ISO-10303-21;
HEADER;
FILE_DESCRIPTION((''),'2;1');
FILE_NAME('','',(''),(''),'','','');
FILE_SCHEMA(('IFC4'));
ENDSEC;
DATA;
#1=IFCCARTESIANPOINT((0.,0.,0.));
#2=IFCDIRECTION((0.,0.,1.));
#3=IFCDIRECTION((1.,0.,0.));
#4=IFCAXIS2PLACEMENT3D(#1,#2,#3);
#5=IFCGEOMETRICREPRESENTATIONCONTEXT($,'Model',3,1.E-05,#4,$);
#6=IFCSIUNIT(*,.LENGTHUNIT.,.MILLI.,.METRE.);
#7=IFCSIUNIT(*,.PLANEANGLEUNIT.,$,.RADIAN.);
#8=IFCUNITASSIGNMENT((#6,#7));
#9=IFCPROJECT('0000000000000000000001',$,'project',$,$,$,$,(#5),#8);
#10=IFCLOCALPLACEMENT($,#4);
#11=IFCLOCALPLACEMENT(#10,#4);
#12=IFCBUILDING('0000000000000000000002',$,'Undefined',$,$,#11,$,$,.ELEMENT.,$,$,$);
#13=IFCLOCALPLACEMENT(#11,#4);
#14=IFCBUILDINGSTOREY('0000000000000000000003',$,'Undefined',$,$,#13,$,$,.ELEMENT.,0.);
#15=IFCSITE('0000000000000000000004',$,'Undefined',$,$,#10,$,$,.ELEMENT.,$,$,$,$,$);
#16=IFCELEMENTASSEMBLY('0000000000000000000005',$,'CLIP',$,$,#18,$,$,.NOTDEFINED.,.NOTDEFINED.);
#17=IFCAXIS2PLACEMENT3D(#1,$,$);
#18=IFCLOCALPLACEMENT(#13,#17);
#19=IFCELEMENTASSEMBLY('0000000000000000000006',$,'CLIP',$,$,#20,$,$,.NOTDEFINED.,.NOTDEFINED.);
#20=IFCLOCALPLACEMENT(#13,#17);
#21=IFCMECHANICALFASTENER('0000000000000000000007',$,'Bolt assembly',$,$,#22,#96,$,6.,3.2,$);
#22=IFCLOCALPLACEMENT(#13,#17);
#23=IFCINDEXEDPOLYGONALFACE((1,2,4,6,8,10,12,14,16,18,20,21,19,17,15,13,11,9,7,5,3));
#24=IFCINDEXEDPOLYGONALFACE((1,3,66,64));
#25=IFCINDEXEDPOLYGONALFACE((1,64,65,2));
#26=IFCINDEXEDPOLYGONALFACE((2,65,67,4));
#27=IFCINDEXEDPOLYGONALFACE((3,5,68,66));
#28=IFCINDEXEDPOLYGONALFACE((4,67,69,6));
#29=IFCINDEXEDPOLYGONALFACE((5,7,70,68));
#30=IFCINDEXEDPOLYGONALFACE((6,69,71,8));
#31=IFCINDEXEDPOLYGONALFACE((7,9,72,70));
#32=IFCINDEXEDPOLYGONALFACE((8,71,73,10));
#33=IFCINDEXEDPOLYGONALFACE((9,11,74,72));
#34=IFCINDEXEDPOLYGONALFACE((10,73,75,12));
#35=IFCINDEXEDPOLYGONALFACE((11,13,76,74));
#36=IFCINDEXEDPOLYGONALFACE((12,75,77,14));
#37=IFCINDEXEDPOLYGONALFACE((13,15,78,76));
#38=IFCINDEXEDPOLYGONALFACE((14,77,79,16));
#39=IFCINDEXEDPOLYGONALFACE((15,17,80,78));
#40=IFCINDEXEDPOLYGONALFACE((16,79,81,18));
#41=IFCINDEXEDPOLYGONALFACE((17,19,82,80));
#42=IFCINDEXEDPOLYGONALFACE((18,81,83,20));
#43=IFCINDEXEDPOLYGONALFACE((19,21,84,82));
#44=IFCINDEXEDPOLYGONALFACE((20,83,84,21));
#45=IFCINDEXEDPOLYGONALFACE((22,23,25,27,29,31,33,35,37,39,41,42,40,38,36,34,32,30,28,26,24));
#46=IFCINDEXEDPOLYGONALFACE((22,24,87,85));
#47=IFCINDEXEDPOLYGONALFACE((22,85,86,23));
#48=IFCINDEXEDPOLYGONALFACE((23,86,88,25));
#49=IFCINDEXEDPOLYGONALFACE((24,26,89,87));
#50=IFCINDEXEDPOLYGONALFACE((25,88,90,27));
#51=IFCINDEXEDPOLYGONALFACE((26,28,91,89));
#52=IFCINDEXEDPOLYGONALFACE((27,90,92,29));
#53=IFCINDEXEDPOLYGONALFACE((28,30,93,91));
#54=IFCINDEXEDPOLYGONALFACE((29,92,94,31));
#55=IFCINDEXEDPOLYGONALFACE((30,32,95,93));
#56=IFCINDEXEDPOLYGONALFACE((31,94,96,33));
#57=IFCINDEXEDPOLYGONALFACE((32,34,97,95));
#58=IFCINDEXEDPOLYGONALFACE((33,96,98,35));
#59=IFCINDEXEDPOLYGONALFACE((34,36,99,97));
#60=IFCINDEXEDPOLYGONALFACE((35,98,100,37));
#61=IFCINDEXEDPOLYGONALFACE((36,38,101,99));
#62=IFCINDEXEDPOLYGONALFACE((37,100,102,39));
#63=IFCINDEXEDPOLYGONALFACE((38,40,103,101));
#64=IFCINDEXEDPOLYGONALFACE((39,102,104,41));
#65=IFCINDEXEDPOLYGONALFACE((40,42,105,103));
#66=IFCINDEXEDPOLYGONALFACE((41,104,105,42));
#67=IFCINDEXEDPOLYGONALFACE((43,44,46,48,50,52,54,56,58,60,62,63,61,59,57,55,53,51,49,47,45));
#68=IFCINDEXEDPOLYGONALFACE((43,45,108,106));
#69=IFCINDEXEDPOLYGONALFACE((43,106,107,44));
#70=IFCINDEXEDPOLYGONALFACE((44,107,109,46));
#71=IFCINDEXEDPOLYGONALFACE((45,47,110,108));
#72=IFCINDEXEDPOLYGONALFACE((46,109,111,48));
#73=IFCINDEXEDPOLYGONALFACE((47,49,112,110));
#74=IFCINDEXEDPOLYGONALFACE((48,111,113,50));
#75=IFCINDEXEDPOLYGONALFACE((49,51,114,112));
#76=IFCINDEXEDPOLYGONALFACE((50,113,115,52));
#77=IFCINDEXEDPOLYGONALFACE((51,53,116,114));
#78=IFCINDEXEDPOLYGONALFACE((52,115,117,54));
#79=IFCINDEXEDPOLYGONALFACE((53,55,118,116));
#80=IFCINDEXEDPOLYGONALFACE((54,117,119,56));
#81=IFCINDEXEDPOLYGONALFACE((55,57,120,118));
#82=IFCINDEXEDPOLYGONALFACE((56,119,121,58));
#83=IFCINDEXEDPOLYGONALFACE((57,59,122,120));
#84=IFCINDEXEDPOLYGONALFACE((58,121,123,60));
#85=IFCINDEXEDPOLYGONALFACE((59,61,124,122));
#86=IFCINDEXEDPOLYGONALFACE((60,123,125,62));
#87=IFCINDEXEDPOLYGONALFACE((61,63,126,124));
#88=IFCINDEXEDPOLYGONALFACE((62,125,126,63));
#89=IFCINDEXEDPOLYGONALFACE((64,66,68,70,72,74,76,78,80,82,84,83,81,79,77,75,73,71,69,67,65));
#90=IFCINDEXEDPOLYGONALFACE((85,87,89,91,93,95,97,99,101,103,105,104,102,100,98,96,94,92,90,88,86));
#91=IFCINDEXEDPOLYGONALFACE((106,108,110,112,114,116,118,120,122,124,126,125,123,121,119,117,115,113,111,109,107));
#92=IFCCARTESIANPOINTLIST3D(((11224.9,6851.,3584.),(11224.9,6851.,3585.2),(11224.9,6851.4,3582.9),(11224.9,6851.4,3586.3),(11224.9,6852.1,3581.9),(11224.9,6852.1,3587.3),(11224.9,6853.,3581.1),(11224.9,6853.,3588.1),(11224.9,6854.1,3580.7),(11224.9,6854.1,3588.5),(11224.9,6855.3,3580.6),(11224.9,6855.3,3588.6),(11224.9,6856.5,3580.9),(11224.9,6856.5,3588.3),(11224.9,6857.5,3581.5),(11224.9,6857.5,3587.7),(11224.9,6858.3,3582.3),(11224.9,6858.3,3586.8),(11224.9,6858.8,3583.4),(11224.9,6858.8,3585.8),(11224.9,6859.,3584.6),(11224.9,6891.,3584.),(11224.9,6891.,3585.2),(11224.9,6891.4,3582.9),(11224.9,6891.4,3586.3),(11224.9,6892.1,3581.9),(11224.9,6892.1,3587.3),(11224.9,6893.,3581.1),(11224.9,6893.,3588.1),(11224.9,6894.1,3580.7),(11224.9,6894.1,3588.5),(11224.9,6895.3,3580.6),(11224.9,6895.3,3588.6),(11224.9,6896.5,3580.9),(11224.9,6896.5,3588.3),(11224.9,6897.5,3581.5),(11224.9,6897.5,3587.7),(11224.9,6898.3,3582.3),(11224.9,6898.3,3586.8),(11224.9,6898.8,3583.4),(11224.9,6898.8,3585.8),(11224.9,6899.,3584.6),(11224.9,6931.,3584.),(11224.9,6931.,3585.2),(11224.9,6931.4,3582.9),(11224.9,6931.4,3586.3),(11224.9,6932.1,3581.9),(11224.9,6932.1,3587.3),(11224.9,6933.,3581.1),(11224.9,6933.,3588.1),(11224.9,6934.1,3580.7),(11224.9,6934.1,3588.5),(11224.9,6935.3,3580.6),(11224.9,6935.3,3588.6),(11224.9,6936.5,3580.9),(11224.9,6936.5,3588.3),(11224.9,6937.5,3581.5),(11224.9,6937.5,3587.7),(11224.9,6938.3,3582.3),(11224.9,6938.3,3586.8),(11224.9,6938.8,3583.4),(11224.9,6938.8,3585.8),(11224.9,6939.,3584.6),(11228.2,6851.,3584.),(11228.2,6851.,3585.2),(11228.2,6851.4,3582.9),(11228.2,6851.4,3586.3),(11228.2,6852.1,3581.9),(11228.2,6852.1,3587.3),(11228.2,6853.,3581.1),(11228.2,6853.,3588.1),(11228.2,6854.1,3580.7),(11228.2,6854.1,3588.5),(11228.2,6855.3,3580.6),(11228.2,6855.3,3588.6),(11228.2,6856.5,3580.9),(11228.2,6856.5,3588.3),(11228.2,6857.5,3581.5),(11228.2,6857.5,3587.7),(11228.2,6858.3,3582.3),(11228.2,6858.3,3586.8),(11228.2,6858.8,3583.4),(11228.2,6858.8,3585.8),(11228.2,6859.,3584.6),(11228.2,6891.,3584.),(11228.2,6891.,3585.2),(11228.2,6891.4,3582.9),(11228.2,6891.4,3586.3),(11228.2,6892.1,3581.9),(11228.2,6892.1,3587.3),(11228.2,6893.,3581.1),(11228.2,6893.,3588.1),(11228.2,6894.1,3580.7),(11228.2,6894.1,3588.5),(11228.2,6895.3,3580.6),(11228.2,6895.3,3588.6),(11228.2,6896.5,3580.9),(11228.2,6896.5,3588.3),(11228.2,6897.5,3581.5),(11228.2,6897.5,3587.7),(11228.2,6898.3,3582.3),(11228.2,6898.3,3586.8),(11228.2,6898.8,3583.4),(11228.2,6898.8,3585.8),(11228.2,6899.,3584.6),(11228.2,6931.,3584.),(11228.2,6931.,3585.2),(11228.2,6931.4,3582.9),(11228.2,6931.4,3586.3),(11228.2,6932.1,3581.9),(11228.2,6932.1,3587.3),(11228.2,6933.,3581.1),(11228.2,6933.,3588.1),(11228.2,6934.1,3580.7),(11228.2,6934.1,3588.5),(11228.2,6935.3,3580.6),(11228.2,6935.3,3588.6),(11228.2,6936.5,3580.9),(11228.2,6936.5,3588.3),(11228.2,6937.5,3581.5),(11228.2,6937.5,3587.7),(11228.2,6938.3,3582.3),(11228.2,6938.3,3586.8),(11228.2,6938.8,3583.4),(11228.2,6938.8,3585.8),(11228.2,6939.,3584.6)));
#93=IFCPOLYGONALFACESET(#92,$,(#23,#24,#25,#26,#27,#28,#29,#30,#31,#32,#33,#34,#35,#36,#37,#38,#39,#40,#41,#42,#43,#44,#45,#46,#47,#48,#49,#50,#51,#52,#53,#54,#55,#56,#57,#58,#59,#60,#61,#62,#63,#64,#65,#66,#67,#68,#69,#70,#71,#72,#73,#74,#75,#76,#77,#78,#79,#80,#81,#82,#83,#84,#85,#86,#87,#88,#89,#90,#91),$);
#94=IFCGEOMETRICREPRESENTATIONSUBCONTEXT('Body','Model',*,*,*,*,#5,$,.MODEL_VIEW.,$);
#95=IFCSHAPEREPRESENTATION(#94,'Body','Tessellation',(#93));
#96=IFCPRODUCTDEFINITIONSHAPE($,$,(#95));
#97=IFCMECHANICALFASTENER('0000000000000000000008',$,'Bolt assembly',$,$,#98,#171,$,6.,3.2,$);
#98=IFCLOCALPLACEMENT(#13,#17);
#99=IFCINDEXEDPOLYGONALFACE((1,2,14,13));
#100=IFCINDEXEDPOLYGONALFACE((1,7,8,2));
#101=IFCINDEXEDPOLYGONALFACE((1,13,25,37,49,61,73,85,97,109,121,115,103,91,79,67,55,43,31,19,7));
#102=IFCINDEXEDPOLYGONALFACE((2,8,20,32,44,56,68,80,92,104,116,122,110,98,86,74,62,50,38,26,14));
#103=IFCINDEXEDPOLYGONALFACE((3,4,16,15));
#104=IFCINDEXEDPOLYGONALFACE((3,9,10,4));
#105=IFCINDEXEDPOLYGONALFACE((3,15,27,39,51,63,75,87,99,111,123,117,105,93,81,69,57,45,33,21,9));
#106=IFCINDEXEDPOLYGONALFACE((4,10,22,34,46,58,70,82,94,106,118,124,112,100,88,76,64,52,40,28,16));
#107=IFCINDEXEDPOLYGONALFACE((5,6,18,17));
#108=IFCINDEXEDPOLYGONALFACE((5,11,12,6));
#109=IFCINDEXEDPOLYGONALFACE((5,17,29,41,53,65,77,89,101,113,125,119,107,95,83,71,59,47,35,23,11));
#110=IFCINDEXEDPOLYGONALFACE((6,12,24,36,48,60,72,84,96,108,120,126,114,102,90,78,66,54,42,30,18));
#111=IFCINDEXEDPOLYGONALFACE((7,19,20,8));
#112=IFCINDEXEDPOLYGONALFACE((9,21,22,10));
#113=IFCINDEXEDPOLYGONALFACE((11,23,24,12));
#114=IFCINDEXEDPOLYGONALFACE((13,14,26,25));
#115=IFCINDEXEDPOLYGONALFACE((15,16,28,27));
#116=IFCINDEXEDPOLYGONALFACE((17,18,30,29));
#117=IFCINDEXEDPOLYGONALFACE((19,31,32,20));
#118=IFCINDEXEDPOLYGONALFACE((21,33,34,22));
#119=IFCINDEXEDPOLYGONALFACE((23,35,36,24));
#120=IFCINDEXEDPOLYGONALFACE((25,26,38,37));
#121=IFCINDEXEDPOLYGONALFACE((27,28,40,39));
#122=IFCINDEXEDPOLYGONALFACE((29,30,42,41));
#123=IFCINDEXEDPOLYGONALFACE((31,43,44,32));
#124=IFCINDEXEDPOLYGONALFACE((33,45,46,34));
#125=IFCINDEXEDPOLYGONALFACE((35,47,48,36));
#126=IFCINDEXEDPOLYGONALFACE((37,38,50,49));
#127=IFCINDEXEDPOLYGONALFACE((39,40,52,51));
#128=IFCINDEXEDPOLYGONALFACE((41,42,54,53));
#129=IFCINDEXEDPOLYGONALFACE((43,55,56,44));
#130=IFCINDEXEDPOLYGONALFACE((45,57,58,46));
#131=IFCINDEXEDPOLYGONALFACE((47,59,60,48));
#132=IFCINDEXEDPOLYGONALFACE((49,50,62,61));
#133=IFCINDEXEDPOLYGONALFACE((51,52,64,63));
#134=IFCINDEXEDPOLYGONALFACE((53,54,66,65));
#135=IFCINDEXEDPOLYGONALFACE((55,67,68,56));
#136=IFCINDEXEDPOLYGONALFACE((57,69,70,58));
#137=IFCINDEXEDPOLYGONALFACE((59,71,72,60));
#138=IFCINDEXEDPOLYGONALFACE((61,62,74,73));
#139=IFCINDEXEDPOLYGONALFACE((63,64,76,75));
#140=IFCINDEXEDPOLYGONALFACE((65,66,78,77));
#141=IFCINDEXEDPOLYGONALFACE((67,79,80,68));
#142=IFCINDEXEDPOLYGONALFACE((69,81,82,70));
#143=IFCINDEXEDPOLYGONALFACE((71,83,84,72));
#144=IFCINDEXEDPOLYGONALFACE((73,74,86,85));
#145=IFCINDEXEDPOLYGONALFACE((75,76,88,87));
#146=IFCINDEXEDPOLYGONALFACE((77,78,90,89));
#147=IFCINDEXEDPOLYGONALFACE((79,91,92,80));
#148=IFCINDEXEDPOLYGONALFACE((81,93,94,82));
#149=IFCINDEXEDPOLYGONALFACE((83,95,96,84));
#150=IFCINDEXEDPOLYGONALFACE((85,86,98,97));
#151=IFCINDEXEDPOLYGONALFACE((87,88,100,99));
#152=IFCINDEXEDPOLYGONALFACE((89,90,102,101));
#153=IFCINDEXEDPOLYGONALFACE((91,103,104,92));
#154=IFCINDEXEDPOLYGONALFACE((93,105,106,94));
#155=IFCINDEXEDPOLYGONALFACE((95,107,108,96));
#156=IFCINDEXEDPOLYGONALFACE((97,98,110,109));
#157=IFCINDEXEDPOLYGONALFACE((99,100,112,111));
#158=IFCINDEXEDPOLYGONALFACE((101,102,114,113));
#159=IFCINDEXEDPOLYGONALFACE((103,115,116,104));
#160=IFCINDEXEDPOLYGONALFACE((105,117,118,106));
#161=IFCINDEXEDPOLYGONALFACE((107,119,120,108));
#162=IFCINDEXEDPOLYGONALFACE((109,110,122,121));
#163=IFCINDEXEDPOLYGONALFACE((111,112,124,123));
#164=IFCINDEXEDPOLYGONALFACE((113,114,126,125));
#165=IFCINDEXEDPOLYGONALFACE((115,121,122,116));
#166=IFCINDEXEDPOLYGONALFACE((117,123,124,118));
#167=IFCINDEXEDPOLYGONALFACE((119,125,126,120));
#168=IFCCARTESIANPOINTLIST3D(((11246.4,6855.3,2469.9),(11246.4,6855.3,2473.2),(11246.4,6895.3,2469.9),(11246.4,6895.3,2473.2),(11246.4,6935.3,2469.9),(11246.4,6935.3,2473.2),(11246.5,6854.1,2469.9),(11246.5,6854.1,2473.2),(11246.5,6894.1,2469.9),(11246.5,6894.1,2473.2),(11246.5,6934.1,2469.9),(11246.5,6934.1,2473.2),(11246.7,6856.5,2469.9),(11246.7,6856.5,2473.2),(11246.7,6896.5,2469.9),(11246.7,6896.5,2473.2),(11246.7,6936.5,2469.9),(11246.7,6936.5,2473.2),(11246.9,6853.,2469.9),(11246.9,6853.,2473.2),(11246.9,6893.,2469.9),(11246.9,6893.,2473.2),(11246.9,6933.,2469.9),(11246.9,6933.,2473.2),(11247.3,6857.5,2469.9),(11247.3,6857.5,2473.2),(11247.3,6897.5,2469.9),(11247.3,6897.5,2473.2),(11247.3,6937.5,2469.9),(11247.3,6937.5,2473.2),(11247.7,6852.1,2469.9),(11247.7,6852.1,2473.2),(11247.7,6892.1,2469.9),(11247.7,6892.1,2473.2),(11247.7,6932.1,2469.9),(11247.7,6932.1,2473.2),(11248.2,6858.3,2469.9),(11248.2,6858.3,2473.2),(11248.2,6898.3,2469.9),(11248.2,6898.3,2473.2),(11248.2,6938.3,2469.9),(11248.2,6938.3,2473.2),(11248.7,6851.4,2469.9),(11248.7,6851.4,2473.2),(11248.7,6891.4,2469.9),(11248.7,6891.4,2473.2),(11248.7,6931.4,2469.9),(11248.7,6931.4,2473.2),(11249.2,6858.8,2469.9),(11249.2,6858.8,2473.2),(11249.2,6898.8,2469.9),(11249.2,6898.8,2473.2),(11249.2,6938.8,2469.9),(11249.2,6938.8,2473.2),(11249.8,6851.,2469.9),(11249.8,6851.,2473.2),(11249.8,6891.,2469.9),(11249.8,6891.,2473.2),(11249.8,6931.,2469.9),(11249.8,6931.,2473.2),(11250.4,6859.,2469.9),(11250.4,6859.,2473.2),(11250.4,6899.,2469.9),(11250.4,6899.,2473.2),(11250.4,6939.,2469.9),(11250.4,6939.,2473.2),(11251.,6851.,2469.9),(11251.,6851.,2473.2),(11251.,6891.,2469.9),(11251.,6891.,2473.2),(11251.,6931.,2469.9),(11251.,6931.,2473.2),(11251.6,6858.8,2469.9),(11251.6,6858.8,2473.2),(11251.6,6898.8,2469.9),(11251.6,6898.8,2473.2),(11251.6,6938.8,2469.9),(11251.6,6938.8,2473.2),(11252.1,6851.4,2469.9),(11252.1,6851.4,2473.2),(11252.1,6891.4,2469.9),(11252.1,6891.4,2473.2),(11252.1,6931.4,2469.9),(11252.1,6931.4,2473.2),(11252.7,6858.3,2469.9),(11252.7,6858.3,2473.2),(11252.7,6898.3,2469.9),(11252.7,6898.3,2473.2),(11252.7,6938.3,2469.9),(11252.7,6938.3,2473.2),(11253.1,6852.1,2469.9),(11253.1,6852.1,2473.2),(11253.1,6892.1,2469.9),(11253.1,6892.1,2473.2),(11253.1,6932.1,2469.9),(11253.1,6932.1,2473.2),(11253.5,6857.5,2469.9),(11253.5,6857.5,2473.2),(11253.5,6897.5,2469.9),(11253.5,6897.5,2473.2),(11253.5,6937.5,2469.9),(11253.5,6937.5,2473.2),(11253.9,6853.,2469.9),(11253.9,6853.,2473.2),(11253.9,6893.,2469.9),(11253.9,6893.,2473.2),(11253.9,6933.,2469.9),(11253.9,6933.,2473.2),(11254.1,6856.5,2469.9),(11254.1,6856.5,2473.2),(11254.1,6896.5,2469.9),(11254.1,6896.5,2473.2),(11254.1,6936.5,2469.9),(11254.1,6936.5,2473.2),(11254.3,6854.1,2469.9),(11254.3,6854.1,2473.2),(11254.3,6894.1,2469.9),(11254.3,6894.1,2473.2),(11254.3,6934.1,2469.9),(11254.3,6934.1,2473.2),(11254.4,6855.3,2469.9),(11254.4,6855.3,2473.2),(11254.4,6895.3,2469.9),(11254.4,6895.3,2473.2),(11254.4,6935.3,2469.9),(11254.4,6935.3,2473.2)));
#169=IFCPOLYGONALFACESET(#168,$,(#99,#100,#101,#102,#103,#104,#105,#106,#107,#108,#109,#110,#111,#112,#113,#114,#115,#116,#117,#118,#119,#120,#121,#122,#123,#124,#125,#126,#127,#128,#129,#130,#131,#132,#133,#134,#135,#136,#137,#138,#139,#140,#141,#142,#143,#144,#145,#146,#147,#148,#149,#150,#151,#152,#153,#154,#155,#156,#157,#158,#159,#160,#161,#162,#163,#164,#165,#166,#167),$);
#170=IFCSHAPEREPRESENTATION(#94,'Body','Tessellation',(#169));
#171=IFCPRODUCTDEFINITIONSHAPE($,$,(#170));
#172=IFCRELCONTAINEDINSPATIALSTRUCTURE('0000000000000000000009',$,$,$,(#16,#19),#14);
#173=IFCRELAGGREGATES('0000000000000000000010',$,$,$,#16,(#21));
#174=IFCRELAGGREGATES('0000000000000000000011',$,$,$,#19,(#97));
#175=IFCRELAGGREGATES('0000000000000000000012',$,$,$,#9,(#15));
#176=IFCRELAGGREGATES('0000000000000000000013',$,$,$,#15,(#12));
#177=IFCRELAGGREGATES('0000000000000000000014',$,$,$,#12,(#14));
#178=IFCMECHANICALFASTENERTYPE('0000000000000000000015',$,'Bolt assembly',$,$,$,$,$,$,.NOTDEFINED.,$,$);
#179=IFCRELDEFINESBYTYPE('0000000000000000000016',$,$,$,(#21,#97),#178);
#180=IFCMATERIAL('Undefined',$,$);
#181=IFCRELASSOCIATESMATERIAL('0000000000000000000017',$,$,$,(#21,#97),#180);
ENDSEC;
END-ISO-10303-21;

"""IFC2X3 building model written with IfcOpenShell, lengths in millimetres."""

from ifc_helpers import new_model, si_unit, frame, origin_with_axes, origin_2d_with_axis, place, context, subcontext, project, spatial, circle, extrude, source, transform, mapped, material, type_object, element, aggregate, save


model = new_model("IFC2X3")

# Units and contexts
model_context = context("Model", 3, precision=1e-05, world=origin_with_axes())
body_context = subcontext(model_context, "Body", "Model", "MODEL_VIEW")
ifc_project = project(units=[si_unit("LENGTHUNIT", "METRE", prefix="MILLI"), si_unit("PLANEANGLEUNIT", "RADIAN")], contexts=[model_context])

# Site, building, storey
site_placement = place(None, origin_with_axes())
site = spatial("IfcSite", under=ifc_project, at=site_placement, Name="Undefined", CompositionType="ELEMENT")
building_placement = place(site_placement, origin_with_axes())
building = spatial("IfcBuilding", under=site, at=building_placement, Name="Undefined", CompositionType="ELEMENT")
storey_placement = place(building_placement, origin_with_axes())
storey = spatial("IfcBuildingStorey", under=building, at=storey_placement, Name="Undefined", CompositionType="ELEMENT", Elevation=0.0)

# Element assemblies
assembly_1_placement = place(storey_placement, origin_with_axes())
assembly_1 = element("IfcElementAssembly", 1, at=assembly_1_placement, inside=storey, Name="CLIP", AssemblyPlace="NOTDEFINED", PredefinedType="NOTDEFINED")
assembly_2_placement = place(storey_placement, origin_with_axes())
assembly_2 = element("IfcElementAssembly", 2, at=assembly_2_placement, inside=storey, Name="CLIP", AssemblyPlace="NOTDEFINED", PredefinedType="NOTDEFINED")

# Mechanical fasteners
ifc_material_1 = material(Name="Undefined")
mechanical_fastener_type = type_object("IfcMechanicalFastenerType", Name="Bolt assembly")
shared_shape_1 = source(origin_with_axes(), body_context, "Body", "SweptSolid", [
    extrude(circle(Radius=4.0, at=origin_2d_with_axis()), frame((0.0, -3.2, 0.0), z_axis=(0.0, 1.0, 0.0), x_axis=(1.0, 0.0, 0.0)), (0.0, 0.0, 1.0), 3.3),
])
mechanical_fastener_1_placement = place(assembly_1_placement, frame((11225.0, 6855.0, 3584.6), z_axis=(0.0, 0.0, 1.0), x_axis=(0.0, 1.0, 0.0)))
mechanical_fastener_1 = element("IfcMechanicalFastener", 3, at=mechanical_fastener_1_placement, type_object=mechanical_fastener_type, material=ifc_material_1, Name="Bolt assembly", NominalDiameter=6.0, NominalLength=3.2, context=body_context, shape_type="MappedRepresentation", body=[
    mapped(shared_shape_1, transform((0.0, 0.0, 0.0))),
    mapped(shared_shape_1, transform((40.0, 0.0, 0.0))),
    mapped(shared_shape_1, transform((80.0, 0.0, 0.0))),
])
mechanical_fastener_2_placement = place(assembly_2_placement, frame((11250.4, 6855.0, 2470.0), z_axis=(-1.0, 0.0, 0.0), x_axis=(0.0, 1.0, 0.0)))
mechanical_fastener_2 = element("IfcMechanicalFastener", 4, at=mechanical_fastener_2_placement, type_object=mechanical_fastener_type, material=ifc_material_1, Name="Bolt assembly", NominalDiameter=6.0, NominalLength=3.2, context=body_context, shape_type="MappedRepresentation", body=[
    mapped(shared_shape_1, transform((0.0, 0.0, 0.0))),
    mapped(shared_shape_1, transform((40.0, 0.0, 0.0))),
    mapped(shared_shape_1, transform((80.0, 0.0, 0.0))),
])
aggregate(assembly_1, [mechanical_fastener_1])
aggregate(assembly_2, [mechanical_fastener_2])

save(model, "model.ifc")
